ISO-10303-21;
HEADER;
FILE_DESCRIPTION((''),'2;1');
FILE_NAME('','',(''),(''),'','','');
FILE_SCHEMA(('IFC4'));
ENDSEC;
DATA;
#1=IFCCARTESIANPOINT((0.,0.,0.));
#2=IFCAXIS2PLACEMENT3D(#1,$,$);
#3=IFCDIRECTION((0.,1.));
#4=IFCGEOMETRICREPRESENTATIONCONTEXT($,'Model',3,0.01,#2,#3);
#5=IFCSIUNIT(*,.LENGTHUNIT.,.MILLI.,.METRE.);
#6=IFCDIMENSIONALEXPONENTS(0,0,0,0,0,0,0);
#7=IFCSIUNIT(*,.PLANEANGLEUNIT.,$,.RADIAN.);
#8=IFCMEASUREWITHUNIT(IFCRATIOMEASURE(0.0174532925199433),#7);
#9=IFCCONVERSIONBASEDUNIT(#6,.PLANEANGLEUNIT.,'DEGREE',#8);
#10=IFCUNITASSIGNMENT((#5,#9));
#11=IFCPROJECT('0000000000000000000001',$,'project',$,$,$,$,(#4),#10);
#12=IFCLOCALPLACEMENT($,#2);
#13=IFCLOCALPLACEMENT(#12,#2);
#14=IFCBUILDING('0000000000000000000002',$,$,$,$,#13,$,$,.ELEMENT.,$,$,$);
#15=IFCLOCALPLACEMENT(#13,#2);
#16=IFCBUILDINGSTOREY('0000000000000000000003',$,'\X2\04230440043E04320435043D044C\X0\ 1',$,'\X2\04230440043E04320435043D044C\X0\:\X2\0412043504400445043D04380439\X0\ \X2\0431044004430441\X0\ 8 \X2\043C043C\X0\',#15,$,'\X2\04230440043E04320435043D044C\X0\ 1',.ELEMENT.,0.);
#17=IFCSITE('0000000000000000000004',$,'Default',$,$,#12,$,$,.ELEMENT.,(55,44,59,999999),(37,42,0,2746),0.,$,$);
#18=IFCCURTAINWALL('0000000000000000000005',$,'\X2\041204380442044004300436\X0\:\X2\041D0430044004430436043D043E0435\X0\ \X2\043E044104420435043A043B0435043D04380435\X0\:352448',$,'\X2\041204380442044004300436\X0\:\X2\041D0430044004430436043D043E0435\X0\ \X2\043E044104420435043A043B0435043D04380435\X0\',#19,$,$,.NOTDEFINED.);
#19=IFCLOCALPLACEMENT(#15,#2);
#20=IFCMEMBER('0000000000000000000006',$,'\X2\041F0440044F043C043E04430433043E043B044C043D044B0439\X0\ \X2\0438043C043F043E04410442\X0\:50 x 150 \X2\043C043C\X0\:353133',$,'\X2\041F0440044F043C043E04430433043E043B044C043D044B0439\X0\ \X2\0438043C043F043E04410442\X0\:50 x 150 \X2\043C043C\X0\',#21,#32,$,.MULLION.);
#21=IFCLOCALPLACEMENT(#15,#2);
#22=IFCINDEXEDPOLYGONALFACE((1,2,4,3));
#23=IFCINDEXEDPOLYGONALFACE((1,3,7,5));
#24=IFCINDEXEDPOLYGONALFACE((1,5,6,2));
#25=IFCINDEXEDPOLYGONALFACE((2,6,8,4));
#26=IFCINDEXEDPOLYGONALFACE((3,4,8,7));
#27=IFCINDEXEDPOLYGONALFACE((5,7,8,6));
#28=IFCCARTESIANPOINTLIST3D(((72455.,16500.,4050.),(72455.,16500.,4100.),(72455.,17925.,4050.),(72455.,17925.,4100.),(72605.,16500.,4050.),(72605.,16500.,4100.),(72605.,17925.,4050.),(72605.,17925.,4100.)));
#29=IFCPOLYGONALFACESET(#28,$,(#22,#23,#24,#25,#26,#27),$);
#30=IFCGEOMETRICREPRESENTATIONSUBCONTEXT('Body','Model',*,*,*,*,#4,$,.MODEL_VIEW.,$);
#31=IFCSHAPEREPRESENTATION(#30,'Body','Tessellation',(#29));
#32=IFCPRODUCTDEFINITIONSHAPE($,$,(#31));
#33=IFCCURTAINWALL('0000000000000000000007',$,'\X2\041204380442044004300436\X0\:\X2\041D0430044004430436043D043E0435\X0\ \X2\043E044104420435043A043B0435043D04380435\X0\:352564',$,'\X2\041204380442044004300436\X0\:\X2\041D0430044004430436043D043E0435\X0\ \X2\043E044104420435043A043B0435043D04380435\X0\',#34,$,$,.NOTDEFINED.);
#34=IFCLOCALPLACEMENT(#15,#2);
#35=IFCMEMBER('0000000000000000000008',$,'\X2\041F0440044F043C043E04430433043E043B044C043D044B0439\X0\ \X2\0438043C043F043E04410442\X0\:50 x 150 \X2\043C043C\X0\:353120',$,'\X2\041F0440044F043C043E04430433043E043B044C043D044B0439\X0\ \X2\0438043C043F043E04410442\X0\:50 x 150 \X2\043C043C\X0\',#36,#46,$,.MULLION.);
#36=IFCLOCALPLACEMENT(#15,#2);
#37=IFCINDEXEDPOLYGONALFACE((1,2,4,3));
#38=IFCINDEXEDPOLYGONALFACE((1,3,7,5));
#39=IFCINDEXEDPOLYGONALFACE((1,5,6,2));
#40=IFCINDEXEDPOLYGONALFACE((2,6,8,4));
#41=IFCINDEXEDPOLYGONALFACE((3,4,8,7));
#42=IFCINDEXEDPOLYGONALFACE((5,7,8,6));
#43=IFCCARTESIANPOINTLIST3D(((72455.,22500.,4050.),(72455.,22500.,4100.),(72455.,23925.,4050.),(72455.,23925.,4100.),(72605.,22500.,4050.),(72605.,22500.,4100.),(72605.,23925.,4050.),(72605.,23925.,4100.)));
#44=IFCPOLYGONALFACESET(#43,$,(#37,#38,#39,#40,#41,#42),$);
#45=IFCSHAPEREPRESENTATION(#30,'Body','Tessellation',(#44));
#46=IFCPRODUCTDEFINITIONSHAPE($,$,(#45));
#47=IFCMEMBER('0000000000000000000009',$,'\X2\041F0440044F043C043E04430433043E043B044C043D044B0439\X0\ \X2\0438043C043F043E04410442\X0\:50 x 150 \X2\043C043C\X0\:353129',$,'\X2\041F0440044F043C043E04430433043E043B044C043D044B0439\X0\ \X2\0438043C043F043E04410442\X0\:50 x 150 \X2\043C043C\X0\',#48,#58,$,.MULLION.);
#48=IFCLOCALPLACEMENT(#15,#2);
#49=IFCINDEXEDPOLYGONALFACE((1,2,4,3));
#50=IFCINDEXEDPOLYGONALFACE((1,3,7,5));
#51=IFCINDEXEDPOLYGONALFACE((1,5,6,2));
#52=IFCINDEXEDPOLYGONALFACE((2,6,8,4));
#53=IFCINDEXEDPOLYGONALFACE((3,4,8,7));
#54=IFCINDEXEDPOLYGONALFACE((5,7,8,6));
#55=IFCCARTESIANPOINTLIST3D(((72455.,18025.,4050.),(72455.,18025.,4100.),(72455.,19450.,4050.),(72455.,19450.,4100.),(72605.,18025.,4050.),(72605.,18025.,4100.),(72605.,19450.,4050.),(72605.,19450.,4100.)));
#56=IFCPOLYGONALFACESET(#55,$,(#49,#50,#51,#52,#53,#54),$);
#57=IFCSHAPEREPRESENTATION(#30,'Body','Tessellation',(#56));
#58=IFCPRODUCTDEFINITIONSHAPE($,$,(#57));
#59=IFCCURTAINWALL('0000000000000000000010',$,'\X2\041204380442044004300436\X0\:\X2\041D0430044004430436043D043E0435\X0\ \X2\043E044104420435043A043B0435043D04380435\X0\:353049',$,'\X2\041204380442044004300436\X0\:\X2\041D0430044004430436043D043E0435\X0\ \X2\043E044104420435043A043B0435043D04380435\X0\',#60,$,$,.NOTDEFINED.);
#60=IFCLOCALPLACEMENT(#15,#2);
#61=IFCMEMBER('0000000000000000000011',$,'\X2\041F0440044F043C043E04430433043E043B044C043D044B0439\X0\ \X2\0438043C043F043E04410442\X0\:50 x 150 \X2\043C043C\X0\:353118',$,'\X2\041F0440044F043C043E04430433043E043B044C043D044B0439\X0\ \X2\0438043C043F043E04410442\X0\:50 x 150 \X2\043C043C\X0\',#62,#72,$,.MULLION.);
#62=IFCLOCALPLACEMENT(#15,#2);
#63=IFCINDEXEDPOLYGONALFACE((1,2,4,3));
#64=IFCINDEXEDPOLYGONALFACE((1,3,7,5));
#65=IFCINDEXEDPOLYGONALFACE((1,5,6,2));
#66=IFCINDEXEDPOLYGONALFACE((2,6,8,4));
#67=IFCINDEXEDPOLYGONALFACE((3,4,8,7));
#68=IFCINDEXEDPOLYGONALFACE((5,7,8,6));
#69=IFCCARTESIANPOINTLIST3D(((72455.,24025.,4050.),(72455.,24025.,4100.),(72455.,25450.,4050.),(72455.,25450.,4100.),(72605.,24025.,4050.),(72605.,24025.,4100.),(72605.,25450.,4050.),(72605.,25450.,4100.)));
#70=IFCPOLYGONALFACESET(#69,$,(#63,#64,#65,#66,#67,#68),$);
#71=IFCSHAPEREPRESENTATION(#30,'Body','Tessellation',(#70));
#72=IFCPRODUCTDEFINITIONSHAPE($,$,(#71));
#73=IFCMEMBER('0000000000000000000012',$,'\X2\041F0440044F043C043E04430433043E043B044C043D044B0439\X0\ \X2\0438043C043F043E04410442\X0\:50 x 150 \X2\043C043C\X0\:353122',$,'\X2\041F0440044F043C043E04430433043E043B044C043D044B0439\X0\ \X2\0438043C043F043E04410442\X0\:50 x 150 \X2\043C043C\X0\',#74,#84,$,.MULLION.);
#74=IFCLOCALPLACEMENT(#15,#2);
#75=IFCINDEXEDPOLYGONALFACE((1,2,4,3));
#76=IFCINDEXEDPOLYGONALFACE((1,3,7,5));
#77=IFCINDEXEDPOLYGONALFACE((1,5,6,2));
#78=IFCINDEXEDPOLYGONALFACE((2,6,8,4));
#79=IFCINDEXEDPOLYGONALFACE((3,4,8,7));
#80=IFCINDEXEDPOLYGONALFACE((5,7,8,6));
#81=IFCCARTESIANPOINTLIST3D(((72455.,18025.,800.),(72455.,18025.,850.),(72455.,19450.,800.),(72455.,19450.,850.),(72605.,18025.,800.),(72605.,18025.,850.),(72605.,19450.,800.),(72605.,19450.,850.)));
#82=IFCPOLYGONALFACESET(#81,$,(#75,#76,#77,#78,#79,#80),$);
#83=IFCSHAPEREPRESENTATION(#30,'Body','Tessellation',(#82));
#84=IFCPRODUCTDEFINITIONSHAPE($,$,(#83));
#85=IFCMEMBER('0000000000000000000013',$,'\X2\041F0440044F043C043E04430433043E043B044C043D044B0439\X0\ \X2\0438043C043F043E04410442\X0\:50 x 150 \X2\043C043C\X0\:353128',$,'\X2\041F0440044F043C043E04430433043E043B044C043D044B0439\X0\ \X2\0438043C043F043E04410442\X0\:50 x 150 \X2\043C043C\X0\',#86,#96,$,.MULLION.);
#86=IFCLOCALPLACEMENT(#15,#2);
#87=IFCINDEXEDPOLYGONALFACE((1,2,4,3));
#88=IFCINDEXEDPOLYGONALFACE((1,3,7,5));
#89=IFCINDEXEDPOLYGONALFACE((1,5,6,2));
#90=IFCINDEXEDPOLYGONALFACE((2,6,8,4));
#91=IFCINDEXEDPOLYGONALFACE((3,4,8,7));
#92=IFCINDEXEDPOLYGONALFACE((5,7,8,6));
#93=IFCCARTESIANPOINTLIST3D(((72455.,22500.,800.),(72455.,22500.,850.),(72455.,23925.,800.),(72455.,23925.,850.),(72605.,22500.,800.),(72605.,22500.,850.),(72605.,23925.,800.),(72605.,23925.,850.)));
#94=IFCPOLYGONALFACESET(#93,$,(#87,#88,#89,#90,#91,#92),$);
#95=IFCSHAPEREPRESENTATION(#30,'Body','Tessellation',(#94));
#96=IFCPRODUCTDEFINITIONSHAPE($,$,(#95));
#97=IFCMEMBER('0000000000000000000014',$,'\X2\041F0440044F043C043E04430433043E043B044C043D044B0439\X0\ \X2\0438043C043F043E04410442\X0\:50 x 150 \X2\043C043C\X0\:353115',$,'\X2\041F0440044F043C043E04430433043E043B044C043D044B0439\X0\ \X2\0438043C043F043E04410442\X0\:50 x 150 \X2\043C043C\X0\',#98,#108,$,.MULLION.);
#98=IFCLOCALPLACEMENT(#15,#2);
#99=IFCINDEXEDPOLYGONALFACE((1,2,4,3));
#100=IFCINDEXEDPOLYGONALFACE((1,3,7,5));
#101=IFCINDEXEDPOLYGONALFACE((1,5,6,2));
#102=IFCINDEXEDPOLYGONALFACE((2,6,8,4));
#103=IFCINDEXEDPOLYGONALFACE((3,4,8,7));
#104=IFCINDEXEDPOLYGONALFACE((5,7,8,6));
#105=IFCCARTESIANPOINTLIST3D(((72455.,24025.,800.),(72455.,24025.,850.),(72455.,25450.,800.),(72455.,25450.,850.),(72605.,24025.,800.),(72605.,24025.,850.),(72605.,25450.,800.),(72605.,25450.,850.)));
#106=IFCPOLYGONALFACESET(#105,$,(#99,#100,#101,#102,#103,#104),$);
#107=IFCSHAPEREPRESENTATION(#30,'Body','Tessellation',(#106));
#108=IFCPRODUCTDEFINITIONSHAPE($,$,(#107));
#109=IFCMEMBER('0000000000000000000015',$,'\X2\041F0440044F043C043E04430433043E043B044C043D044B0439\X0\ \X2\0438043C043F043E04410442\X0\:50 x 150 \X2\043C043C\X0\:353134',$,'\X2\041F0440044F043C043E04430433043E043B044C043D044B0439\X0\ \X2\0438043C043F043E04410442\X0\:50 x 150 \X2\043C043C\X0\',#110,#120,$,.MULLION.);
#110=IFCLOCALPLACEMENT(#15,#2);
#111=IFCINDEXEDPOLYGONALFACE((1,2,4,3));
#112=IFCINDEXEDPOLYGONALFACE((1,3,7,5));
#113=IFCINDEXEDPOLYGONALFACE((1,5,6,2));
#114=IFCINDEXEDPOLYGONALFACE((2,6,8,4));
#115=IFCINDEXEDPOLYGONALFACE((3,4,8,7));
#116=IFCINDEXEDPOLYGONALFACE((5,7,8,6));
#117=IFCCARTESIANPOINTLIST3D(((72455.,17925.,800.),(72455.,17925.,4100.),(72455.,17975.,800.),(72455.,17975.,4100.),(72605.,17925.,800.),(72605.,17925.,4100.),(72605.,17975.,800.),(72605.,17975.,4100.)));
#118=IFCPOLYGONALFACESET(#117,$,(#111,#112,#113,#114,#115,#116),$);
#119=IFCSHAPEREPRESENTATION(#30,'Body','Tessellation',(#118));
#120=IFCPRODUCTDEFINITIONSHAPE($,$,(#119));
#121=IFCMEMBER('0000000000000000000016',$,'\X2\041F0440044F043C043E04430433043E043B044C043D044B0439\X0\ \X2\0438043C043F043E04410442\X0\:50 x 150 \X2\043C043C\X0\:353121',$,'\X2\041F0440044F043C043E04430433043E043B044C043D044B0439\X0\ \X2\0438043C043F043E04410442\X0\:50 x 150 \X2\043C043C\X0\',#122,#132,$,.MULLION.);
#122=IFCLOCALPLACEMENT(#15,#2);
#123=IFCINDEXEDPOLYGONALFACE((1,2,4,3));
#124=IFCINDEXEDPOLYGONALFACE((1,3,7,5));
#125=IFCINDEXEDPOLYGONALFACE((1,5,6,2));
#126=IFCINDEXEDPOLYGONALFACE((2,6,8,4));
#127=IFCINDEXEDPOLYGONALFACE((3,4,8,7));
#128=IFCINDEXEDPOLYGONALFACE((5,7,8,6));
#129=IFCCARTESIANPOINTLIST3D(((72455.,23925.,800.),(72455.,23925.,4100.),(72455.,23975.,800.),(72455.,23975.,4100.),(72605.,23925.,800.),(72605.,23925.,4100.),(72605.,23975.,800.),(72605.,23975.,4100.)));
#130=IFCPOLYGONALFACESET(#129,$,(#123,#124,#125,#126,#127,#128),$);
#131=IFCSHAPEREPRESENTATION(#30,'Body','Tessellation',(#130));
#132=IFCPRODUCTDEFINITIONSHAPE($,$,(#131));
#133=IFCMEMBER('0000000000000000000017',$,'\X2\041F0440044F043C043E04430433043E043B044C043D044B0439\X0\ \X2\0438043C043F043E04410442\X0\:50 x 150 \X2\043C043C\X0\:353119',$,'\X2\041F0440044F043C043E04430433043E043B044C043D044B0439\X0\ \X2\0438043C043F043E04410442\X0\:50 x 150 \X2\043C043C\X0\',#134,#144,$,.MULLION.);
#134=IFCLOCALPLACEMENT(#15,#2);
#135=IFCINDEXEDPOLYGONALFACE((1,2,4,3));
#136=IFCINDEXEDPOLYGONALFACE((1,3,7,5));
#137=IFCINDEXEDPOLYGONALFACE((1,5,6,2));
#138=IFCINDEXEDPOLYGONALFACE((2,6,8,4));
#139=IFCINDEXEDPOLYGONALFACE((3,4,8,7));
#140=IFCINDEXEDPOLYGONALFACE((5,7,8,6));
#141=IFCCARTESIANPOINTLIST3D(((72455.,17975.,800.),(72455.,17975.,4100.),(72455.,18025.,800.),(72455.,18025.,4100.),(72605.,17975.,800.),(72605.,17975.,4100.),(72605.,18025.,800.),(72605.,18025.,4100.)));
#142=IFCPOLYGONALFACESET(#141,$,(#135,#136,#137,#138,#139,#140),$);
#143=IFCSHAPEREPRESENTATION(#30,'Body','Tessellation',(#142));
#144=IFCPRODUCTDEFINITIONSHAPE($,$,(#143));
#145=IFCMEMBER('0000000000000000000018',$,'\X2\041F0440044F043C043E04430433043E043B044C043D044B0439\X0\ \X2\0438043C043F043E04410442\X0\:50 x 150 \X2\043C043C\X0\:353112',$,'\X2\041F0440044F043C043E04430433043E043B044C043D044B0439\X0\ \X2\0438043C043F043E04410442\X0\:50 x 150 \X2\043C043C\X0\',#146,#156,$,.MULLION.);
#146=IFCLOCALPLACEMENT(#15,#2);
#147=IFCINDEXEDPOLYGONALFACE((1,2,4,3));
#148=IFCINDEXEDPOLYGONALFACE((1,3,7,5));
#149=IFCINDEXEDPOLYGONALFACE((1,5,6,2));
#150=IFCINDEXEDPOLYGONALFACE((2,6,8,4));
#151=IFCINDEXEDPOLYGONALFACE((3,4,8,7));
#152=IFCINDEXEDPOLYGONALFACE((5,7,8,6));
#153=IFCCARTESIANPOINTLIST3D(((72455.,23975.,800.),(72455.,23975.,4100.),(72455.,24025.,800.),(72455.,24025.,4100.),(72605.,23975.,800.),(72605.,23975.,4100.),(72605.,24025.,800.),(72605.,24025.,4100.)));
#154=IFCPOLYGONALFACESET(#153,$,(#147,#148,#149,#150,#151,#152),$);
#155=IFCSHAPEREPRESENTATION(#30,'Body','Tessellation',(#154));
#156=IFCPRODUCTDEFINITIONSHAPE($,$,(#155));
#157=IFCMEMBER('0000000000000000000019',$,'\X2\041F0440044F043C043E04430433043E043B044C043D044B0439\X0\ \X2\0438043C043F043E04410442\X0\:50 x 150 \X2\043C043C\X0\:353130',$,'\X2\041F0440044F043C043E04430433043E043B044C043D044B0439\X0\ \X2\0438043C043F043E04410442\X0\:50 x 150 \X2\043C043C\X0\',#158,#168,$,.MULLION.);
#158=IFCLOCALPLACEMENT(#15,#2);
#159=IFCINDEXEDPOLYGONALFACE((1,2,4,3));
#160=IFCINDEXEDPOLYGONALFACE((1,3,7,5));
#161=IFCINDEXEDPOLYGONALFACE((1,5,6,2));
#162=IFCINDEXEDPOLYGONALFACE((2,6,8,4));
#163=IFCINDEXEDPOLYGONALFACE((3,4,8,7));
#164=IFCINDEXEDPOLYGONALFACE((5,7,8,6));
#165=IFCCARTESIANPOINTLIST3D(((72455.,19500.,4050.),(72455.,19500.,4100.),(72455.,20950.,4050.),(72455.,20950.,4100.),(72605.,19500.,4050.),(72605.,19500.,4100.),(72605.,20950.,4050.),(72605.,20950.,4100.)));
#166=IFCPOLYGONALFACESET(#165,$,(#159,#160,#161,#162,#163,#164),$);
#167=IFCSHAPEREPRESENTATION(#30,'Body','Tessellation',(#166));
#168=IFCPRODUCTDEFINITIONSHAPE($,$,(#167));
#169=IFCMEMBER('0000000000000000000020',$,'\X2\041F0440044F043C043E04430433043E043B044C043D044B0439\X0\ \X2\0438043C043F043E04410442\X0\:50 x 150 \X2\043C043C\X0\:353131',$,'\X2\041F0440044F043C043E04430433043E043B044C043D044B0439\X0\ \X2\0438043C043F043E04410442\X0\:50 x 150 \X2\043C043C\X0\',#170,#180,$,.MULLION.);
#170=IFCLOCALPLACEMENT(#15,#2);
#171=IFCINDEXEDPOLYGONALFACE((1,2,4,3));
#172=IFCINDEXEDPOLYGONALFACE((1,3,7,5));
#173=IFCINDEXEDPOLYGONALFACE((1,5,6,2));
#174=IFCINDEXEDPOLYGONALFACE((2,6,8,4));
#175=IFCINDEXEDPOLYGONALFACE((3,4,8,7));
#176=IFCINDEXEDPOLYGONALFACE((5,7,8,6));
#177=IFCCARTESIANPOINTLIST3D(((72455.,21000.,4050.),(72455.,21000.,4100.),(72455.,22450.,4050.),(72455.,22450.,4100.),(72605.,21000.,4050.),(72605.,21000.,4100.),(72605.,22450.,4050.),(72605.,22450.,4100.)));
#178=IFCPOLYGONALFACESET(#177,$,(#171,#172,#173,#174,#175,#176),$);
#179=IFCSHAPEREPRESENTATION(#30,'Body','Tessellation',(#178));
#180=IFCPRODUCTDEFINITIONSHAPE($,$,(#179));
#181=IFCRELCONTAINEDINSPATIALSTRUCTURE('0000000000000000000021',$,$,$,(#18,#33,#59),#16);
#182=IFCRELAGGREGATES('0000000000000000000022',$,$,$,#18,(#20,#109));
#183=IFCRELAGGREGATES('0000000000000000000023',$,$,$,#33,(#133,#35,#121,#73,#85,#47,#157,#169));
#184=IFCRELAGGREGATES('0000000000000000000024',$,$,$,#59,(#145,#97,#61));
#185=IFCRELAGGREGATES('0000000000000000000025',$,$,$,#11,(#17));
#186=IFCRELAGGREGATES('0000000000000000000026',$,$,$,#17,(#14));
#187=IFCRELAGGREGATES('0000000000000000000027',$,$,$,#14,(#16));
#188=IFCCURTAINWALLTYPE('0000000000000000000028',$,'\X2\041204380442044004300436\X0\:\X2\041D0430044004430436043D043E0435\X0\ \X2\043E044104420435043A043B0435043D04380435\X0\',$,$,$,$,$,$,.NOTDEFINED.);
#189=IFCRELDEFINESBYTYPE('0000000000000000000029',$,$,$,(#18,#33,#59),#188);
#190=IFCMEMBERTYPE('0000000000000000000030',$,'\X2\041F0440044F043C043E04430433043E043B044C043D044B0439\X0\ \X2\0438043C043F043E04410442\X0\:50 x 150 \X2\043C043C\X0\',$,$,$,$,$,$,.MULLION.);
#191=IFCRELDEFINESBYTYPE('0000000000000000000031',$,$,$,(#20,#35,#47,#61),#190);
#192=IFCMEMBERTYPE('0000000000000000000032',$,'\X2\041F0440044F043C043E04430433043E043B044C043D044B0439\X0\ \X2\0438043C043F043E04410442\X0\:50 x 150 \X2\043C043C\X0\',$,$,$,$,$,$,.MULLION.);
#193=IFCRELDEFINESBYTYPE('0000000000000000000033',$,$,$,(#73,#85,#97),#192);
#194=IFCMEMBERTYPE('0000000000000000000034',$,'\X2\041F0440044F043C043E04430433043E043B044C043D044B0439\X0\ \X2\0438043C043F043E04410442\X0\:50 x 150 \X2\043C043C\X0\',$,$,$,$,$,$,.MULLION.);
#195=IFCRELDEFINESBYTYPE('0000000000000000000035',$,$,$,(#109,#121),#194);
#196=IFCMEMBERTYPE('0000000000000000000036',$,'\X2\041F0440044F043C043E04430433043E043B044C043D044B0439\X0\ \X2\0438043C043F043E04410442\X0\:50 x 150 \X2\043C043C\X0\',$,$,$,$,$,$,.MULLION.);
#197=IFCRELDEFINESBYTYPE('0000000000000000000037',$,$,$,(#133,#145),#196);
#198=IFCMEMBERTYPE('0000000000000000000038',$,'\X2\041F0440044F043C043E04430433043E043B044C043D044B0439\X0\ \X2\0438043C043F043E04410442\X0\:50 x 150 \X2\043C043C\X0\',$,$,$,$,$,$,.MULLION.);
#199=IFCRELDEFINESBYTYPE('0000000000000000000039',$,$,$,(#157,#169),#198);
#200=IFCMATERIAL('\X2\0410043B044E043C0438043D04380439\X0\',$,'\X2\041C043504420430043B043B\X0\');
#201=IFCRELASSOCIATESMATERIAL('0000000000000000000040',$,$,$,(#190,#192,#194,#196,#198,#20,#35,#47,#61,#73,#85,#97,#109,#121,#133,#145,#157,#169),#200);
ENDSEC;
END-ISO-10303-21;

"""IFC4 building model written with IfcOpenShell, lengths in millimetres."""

from ifc_helpers import new_model, entity, si_unit, converted_unit, direction, frame, origin, origin_2d_with_axis, place, context, subcontext, project, spatial, rectangle, extrude, source, transform, mapped, material, material_profile, profile_set, profile_usage, type_object, type_shapes, element, aggregate, save


model = new_model("IFC4")

# Units and contexts
model_context = context("Model", 3, precision=0.01, world=origin(), true_north=direction((0.0, 1.0)))
body_context = subcontext(model_context, "Body", "Model", "MODEL_VIEW")
ifc_project = project(units=[si_unit("LENGTHUNIT", "METRE", prefix="MILLI"), converted_unit("PLANEANGLEUNIT", "DEGREE", entity("IfcRatioMeasure", 0.0174532925199433), si_unit("PLANEANGLEUNIT", "RADIAN"), dimensions=[0, 0, 0, 0, 0, 0, 0])], contexts=[model_context])

# Site, building, storey
site_placement = place(None, origin())
site = spatial("IfcSite", under=ifc_project, at=site_placement, Name="Default", CompositionType="ELEMENT", RefLatitude=(55, 44, 59, 999999), RefLongitude=(37, 42, 0, 2746), RefElevation=0.0)
building_placement = place(site_placement, origin())
building = spatial("IfcBuilding", under=site, at=building_placement, CompositionType="ELEMENT")
storey_placement = place(building_placement, origin())
storey = spatial("IfcBuildingStorey", under=building, at=storey_placement, Name="Уровень 1", ObjectType="Уровень:Верхний брус 8 мм", LongName="Уровень 1", CompositionType="ELEMENT", Elevation=0.0)

# Curtain wall, member
curtain_wall_type = type_object("IfcCurtainWallType", Name="Витраж:Наружное остекление", PredefinedType="NOTDEFINED")
curtain_wall_1_placement = place(storey_placement, origin())
curtain_wall_1 = element("IfcCurtainWall", 1, at=curtain_wall_1_placement, inside=storey, type_object=curtain_wall_type, Name="Витраж:Наружное остекление:352448", ObjectType="Витраж:Наружное остекление", PredefinedType="NOTDEFINED")
ifc_material_1 = material(Name="Алюминий", Category="Металл")
ifc_material_profile = material_profile(ifc_material_1, rectangle(XDim=150.0, YDim=50.0, at=origin_2d_with_axis()), Name="50 x 150 мм")
ifc_profile_set = profile_set([ifc_material_profile], Name="50 x 150 мм")
ifc_profile_usage_1 = profile_usage(ifc_profile_set)
member_type_1 = type_object("IfcMemberType", Name="Прямоугольный импост:50 x 150 мм", PredefinedType="MULLION", material=ifc_profile_set)
shared_shape_1 = source(origin(), body_context, "Body", "SweptSolid", [
    extrude(rectangle(XDim=150.0, YDim=50.0, at=origin_2d_with_axis()), frame((-25.0, 0.0, -1425.0), z_axis=(0.0, 0.0, 1.0), x_axis=(0.0, -1.0, 0.0)), (0.0, 0.0, 1.0), 1425.0),
])
type_shapes(member_type_1, [shared_shape_1])
member_1_placement = place(storey_placement, frame((72530.0, 17925.0, 4100.0), z_axis=(0.0, 1.0, 0.0), x_axis=(0.0, 0.0, 1.0)))
member_1 = element("IfcMember", 2, at=member_1_placement, type_object=member_type_1, material=ifc_profile_usage_1, Name="Прямоугольный импост:50 x 150 мм:353133", ObjectType="Прямоугольный импост:50 x 150 мм", PredefinedType="MULLION", context=body_context, shape_type="MappedRepresentation", body=[
    mapped(shared_shape_1, transform((0.0, 0.0, 0.0), scale=1.0)),
])

# Curtain wall, members
curtain_wall_2_placement = place(storey_placement, origin())
curtain_wall_2 = element("IfcCurtainWall", 3, at=curtain_wall_2_placement, inside=storey, type_object=curtain_wall_type, Name="Витраж:Наружное остекление:352564", ObjectType="Витраж:Наружное остекление", PredefinedType="NOTDEFINED")
ifc_profile_usage_2 = profile_usage(ifc_profile_set)
member_2_placement = place(storey_placement, frame((72530.0, 23925.0, 4100.0), z_axis=(0.0, 1.0, 0.0), x_axis=(0.0, 0.0, 1.0)))
member_2 = element("IfcMember", 4, at=member_2_placement, type_object=member_type_1, material=ifc_profile_usage_2, Name="Прямоугольный импост:50 x 150 мм:353120", ObjectType="Прямоугольный импост:50 x 150 мм", PredefinedType="MULLION", context=body_context, shape_type="MappedRepresentation", body=[
    mapped(shared_shape_1, transform((0.0, 0.0, 0.0), scale=1.0)),
])
ifc_profile_usage_3 = profile_usage(ifc_profile_set)
member_3_placement = place(storey_placement, frame((72530.0, 19450.0, 4100.0), z_axis=(0.0, 1.0, 0.0), x_axis=(0.0, 0.0, 1.0)))
member_3 = element("IfcMember", 5, at=member_3_placement, type_object=member_type_1, material=ifc_profile_usage_3, Name="Прямоугольный импост:50 x 150 мм:353129", ObjectType="Прямоугольный импост:50 x 150 мм", PredefinedType="MULLION", context=body_context, shape_type="MappedRepresentation", body=[
    mapped(shared_shape_1, transform((0.0, 0.0, 0.0), scale=1.0)),
])

# Curtain wall, member
curtain_wall_3_placement = place(storey_placement, origin())
curtain_wall_3 = element("IfcCurtainWall", 6, at=curtain_wall_3_placement, inside=storey, type_object=curtain_wall_type, Name="Витраж:Наружное остекление:353049", ObjectType="Витраж:Наружное остекление", PredefinedType="NOTDEFINED")
ifc_profile_usage_4 = profile_usage(ifc_profile_set)
member_4_placement = place(storey_placement, frame((72530.0, 25450.0, 4100.0), z_axis=(0.0, 1.0, 0.0), x_axis=(0.0, 0.0, 1.0)))
member_4 = element("IfcMember", 7, at=member_4_placement, type_object=member_type_1, material=ifc_profile_usage_4, Name="Прямоугольный импост:50 x 150 мм:353118", ObjectType="Прямоугольный импост:50 x 150 мм", PredefinedType="MULLION", context=body_context, shape_type="MappedRepresentation", body=[
    mapped(shared_shape_1, transform((0.0, 0.0, 0.0), scale=1.0)),
])

# Members
ifc_profile_usage_5 = profile_usage(ifc_profile_set)
member_type_2 = type_object("IfcMemberType", Name="Прямоугольный импост:50 x 150 мм", PredefinedType="MULLION", material=ifc_profile_set)
shared_shape_2 = source(origin(), body_context, "Body", "SweptSolid", [
    extrude(rectangle(XDim=150.0, YDim=50.0, at=origin_2d_with_axis()), frame((-25.0, 0.0, -1425.0), z_axis=(0.0, 0.0, 1.0), x_axis=(0.0, -1.0, 0.0)), (0.0, 0.0, 1.0), 1425.0),
])
type_shapes(member_type_2, [shared_shape_2])
member_5_placement = place(storey_placement, frame((72530.0, 18025.0, 800.0), z_axis=(0.0, -1.0, 0.0), x_axis=(0.0, 0.0, -1.0)))
member_5 = element("IfcMember", 8, at=member_5_placement, type_object=member_type_2, material=ifc_profile_usage_5, Name="Прямоугольный импост:50 x 150 мм:353122", ObjectType="Прямоугольный импост:50 x 150 мм", PredefinedType="MULLION", context=body_context, shape_type="MappedRepresentation", body=[
    mapped(shared_shape_2, transform((0.0, 0.0, 0.0), scale=1.0)),
])
ifc_profile_usage_6 = profile_usage(ifc_profile_set)
member_6_placement = place(storey_placement, frame((72530.0, 22500.0, 800.0), z_axis=(0.0, -1.0, 0.0), x_axis=(0.0, 0.0, -1.0)))
member_6 = element("IfcMember", 9, at=member_6_placement, type_object=member_type_2, material=ifc_profile_usage_6, Name="Прямоугольный импост:50 x 150 мм:353128", ObjectType="Прямоугольный импост:50 x 150 мм", PredefinedType="MULLION", context=body_context, shape_type="MappedRepresentation", body=[
    mapped(shared_shape_2, transform((0.0, 0.0, 0.0), scale=1.0)),
])
ifc_profile_usage_7 = profile_usage(ifc_profile_set)
member_7_placement = place(storey_placement, frame((72530.0, 24025.0, 800.0), z_axis=(0.0, -1.0, 0.0), x_axis=(0.0, 0.0, -1.0)))
member_7 = element("IfcMember", 10, at=member_7_placement, type_object=member_type_2, material=ifc_profile_usage_7, Name="Прямоугольный импост:50 x 150 мм:353115", ObjectType="Прямоугольный импост:50 x 150 мм", PredefinedType="MULLION", context=body_context, shape_type="MappedRepresentation", body=[
    mapped(shared_shape_2, transform((0.0, 0.0, 0.0), scale=1.0)),
])
ifc_profile_usage_8 = profile_usage(ifc_profile_set)
member_type_3 = type_object("IfcMemberType", Name="Прямоугольный импост:50 x 150 мм", PredefinedType="MULLION", material=ifc_profile_set)
shared_shape_3 = source(origin(), body_context, "Body", "SweptSolid", [
    extrude(rectangle(XDim=150.0, YDim=50.0, at=origin_2d_with_axis()), frame((-25.0, 0.0, -3300.0), z_axis=(0.0, 0.0, 1.0), x_axis=(0.0, -1.0, 0.0)), (0.0, 0.0, 1.0), 3300.0),
])
type_shapes(member_type_3, [shared_shape_3])
member_8_placement = place(storey_placement, frame((72530.0, 17975.0, 800.0), z_axis=(0.0, 0.0, -1.0), x_axis=(0.0, 1.0, 0.0)))
member_8 = element("IfcMember", 11, at=member_8_placement, type_object=member_type_3, material=ifc_profile_usage_8, Name="Прямоугольный импост:50 x 150 мм:353134", ObjectType="Прямоугольный импост:50 x 150 мм", PredefinedType="MULLION", context=body_context, shape_type="MappedRepresentation", body=[
    mapped(shared_shape_3, transform((0.0, 0.0, 0.0), scale=1.0)),
])
aggregate(curtain_wall_1, [member_1, member_8])
ifc_profile_usage_9 = profile_usage(ifc_profile_set)
member_9_placement = place(storey_placement, frame((72530.0, 23975.0, 800.0), z_axis=(0.0, 0.0, -1.0), x_axis=(0.0, 1.0, 0.0)))
member_9 = element("IfcMember", 12, at=member_9_placement, type_object=member_type_3, material=ifc_profile_usage_9, Name="Прямоугольный импост:50 x 150 мм:353121", ObjectType="Прямоугольный импост:50 x 150 мм", PredefinedType="MULLION", context=body_context, shape_type="MappedRepresentation", body=[
    mapped(shared_shape_3, transform((0.0, 0.0, 0.0), scale=1.0)),
])
ifc_profile_usage_10 = profile_usage(ifc_profile_set)
member_type_4 = type_object("IfcMemberType", Name="Прямоугольный импост:50 x 150 мм", PredefinedType="MULLION", material=ifc_profile_set)
shared_shape_4 = source(origin(), body_context, "Body", "SweptSolid", [
    extrude(rectangle(XDim=150.0, YDim=50.0, at=origin_2d_with_axis()), frame((-25.0, 0.0, -3300.0), z_axis=(0.0, 0.0, 1.0), x_axis=(0.0, -1.0, 0.0)), (0.0, 0.0, 1.0), 3300.0),
])
type_shapes(member_type_4, [shared_shape_4])
member_10_placement = place(storey_placement, frame((72530.0, 17975.0, 4100.0), z_axis=(0.0, 0.0, 1.0), x_axis=(0.0, -1.0, 0.0)))
member_10 = element("IfcMember", 13, at=member_10_placement, type_object=member_type_4, material=ifc_profile_usage_10, Name="Прямоугольный импост:50 x 150 мм:353119", ObjectType="Прямоугольный импост:50 x 150 мм", PredefinedType="MULLION", context=body_context, shape_type="MappedRepresentation", body=[
    mapped(shared_shape_4, transform((0.0, 0.0, 0.0), scale=1.0)),
])
ifc_profile_usage_11 = profile_usage(ifc_profile_set)
member_11_placement = place(storey_placement, frame((72530.0, 23975.0, 4100.0), z_axis=(0.0, 0.0, 1.0), x_axis=(0.0, -1.0, 0.0)))
member_11 = element("IfcMember", 14, at=member_11_placement, type_object=member_type_4, material=ifc_profile_usage_11, Name="Прямоугольный импост:50 x 150 мм:353112", ObjectType="Прямоугольный импост:50 x 150 мм", PredefinedType="MULLION", context=body_context, shape_type="MappedRepresentation", body=[
    mapped(shared_shape_4, transform((0.0, 0.0, 0.0), scale=1.0)),
])
ifc_profile_usage_12 = profile_usage(ifc_profile_set)
member_type_5 = type_object("IfcMemberType", Name="Прямоугольный импост:50 x 150 мм", PredefinedType="MULLION", material=ifc_profile_set)
shared_shape_5 = source(origin(), body_context, "Body", "SweptSolid", [
    extrude(rectangle(XDim=150.0, YDim=50.0, at=origin_2d_with_axis()), frame((-25.0, 0.0, -1450.0), z_axis=(0.0, 0.0, 1.0), x_axis=(0.0, -1.0, 0.0)), (0.0, 0.0, 1.0), 1450.0),
])
type_shapes(member_type_5, [shared_shape_5])
member_12_placement = place(storey_placement, frame((72530.0, 20950.0, 4100.0), z_axis=(0.0, 1.0, 0.0), x_axis=(0.0, 0.0, 1.0)))
member_12 = element("IfcMember", 15, at=member_12_placement, type_object=member_type_5, material=ifc_profile_usage_12, Name="Прямоугольный импост:50 x 150 мм:353130", ObjectType="Прямоугольный импост:50 x 150 мм", PredefinedType="MULLION", context=body_context, shape_type="MappedRepresentation", body=[
    mapped(shared_shape_5, transform((0.0, 0.0, 0.0), scale=1.0)),
])
ifc_profile_usage_13 = profile_usage(ifc_profile_set)
member_13_placement = place(storey_placement, frame((72530.0, 22450.0, 4100.0), z_axis=(0.0, 1.0, 0.0), x_axis=(0.0, 0.0, 1.0)))
member_13 = element("IfcMember", 16, at=member_13_placement, type_object=member_type_5, material=ifc_profile_usage_13, Name="Прямоугольный импост:50 x 150 мм:353131", ObjectType="Прямоугольный импост:50 x 150 мм", PredefinedType="MULLION", context=body_context, shape_type="MappedRepresentation", body=[
    mapped(shared_shape_5, transform((0.0, 0.0, 0.0), scale=1.0)),
])

aggregate(curtain_wall_2, [member_10, member_2, member_9, member_5, member_6, member_3, member_12, member_13])
aggregate(curtain_wall_3, [member_11, member_7, member_4])

save(model, "model.ifc")
